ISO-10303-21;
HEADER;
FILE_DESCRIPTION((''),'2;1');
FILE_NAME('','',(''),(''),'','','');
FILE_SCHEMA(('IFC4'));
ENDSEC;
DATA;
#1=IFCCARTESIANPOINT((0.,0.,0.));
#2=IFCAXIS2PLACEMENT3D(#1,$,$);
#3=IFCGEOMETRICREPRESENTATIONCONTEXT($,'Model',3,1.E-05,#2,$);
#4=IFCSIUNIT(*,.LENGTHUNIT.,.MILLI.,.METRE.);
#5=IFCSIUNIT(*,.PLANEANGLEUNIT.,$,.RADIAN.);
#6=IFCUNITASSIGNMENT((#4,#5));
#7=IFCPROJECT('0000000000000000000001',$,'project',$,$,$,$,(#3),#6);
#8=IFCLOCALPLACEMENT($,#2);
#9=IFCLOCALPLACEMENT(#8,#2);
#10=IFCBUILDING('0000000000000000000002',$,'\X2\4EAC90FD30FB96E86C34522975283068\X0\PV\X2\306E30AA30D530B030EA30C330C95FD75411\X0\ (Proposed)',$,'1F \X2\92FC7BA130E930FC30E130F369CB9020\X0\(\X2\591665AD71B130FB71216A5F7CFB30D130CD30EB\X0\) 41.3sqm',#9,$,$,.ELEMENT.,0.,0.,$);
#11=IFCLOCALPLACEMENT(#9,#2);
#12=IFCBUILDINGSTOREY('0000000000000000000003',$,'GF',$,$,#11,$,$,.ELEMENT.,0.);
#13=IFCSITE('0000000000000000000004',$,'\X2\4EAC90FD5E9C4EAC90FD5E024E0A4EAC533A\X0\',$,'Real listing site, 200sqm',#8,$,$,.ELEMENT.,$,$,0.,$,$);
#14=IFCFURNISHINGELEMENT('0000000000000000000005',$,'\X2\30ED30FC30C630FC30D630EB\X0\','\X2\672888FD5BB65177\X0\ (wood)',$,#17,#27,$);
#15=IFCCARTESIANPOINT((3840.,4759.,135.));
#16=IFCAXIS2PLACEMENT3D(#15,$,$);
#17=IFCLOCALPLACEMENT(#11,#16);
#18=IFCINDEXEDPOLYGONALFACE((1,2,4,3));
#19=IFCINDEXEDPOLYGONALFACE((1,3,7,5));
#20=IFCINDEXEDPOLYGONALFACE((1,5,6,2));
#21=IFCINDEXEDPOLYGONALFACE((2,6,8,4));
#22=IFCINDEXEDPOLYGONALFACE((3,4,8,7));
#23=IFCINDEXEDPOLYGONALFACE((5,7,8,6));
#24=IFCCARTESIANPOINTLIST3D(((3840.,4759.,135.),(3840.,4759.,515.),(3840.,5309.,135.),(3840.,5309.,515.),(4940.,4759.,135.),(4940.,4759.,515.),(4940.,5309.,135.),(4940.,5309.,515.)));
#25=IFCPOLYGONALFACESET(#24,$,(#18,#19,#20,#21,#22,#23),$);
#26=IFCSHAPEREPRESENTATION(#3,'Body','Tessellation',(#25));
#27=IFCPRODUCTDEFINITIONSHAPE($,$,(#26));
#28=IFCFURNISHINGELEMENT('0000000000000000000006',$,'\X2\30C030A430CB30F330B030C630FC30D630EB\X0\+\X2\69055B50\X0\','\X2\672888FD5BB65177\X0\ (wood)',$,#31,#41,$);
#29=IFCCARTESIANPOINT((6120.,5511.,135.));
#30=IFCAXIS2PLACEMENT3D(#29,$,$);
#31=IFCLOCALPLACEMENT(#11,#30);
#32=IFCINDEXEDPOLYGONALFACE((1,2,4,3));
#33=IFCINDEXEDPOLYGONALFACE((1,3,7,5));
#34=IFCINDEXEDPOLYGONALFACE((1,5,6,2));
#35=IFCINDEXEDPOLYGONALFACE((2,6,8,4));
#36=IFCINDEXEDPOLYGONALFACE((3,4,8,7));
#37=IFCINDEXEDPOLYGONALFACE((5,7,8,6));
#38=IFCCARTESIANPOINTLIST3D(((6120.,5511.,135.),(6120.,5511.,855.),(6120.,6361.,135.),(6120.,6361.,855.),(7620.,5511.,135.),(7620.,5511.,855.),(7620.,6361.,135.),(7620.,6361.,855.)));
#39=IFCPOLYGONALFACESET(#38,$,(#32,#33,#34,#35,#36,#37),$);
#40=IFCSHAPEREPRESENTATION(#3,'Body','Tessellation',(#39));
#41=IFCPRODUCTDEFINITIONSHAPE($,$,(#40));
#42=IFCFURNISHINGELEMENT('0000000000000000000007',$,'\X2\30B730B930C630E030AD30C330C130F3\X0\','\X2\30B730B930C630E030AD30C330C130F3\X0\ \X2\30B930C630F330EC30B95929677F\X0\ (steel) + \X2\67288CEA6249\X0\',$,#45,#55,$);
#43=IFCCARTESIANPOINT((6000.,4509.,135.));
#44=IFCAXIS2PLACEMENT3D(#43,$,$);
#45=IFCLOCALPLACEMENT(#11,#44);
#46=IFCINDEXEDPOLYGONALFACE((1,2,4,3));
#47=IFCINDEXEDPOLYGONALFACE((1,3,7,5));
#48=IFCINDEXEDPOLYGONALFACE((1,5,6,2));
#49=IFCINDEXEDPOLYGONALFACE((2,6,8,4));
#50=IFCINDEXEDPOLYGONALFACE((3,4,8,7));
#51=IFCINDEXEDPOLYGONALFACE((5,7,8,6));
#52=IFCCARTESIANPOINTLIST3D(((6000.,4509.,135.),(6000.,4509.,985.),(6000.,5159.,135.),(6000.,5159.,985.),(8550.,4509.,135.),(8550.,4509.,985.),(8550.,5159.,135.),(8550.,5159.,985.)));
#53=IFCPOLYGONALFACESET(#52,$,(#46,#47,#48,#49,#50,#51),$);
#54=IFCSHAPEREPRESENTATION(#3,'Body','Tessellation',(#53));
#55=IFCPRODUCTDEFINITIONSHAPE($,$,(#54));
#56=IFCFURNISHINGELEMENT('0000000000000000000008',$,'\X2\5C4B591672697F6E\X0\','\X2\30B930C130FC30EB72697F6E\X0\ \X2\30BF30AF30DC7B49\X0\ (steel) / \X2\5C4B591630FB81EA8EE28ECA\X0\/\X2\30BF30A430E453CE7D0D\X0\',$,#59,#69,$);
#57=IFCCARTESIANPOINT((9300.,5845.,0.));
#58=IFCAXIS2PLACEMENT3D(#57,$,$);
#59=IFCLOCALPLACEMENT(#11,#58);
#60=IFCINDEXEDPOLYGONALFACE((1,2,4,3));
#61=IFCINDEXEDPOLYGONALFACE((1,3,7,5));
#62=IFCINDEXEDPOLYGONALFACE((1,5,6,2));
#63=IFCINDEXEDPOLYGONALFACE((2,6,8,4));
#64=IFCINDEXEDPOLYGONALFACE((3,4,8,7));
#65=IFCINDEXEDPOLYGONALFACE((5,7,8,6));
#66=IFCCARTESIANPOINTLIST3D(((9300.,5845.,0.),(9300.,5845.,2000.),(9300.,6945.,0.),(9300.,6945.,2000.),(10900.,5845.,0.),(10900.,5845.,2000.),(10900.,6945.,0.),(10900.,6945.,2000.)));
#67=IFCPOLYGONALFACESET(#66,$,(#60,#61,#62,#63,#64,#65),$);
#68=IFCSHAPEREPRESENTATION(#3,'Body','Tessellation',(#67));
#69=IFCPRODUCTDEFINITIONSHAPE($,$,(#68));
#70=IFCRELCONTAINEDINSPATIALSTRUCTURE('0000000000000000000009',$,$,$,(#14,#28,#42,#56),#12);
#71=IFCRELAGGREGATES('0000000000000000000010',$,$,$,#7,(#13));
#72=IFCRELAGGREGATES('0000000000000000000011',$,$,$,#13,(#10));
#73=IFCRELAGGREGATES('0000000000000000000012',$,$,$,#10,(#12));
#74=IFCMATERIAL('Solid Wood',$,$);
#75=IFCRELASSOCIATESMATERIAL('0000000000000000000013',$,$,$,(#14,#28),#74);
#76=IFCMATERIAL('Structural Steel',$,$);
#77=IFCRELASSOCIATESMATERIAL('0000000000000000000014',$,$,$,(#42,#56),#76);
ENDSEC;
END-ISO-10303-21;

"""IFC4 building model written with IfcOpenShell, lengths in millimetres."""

from ifc_helpers import new_model, si_unit, frame, frame_2d, origin, place, context, project, spatial, rectangle, extrude, material, element, save


model = new_model("IFC4")

# Units and contexts
model_context = context("Model", 3, precision=1e-05, world=origin())
ifc_project = project(units=[si_unit("LENGTHUNIT", "METRE", prefix="MILLI"), si_unit("PLANEANGLEUNIT", "RADIAN")], contexts=[model_context])

# Site, building, storey
site_placement = place(None, origin())
site = spatial("IfcSite", under=ifc_project, at=site_placement, Name="京都府京都市上京区", ObjectType="Real listing site, 200sqm", CompositionType="ELEMENT", RefElevation=0.0)
building_placement = place(site_placement, origin())
building = spatial("IfcBuilding", under=site, at=building_placement, Name="京都・雨水利用とPVのオフグリッド志向 (Proposed)", ObjectType="1F 鋼管ラーメン構造(外断熱・無機系パネル) 41.3sqm", CompositionType="ELEMENT", ElevationOfRefHeight=0.0, ElevationOfTerrain=0.0)
storey_placement = place(building_placement, origin())
storey = spatial("IfcBuildingStorey", under=building, at=storey_placement, Name="GF", CompositionType="ELEMENT", Elevation=0.0)

# Shared definitions
ifc_material_1 = material(Name="Solid Wood")

# Shared definitions
ifc_material_2 = material(Name="Structural Steel")

# Furnishing elements
furnishing_1_placement = place(storey_placement, frame((3840.0, 4759.0, 135.0)))
element("IfcFurnishingElement", 1, at=furnishing_1_placement, inside=storey, material=ifc_material_1, Name="ローテーブル", Description="木製家具 (wood)", context=model_context, shape_type="SweptSolid", body=[
    extrude(rectangle(XDim=1100.0, YDim=550.0, at=frame_2d((550.0, 275.0))), frame((3840.0, 4759.0, 135.0)), (0.0, 0.0, 1.0), 380.0),
])
furnishing_2_placement = place(storey_placement, frame((6120.0, 5511.0, 135.0)))
element("IfcFurnishingElement", 2, at=furnishing_2_placement, inside=storey, material=ifc_material_1, Name="ダイニングテーブル+椅子", Description="木製家具 (wood)", context=model_context, shape_type="SweptSolid", body=[
    extrude(rectangle(XDim=1500.0, YDim=850.0, at=frame_2d((750.0, 425.0))), frame((6120.0, 5511.0, 135.0)), (0.0, 0.0, 1.0), 720.0),
])
furnishing_3_placement = place(storey_placement, frame((6000.0, 4509.0, 135.0)))
element("IfcFurnishingElement", 3, at=furnishing_3_placement, inside=storey, material=ifc_material_2, Name="システムキッチン", Description="システムキッチン ステンレス天板 (steel) + 木質扉", context=model_context, shape_type="SweptSolid", body=[
    extrude(rectangle(XDim=2550.0, YDim=650.0, at=frame_2d((1275.0, 325.0))), frame((6000.0, 4509.0, 135.0)), (0.0, 0.0, 1.0), 850.0),
])
furnishing_4_placement = place(storey_placement, frame((9300.0, 5845.0, 0.0)))
element("IfcFurnishingElement", 4, at=furnishing_4_placement, inside=storey, material=ifc_material_2, Name="屋外物置", Description="スチール物置 タクボ等 (steel) / 屋外・自転車/タイヤ収納", context=model_context, shape_type="SweptSolid", body=[
    extrude(rectangle(XDim=1600.0, YDim=1100.0, at=frame_2d((800.0, 550.0))), frame((9300.0, 5845.0, 0.0)), (0.0, 0.0, 1.0), 2000.0),
])

save(model, "model.ifc")
